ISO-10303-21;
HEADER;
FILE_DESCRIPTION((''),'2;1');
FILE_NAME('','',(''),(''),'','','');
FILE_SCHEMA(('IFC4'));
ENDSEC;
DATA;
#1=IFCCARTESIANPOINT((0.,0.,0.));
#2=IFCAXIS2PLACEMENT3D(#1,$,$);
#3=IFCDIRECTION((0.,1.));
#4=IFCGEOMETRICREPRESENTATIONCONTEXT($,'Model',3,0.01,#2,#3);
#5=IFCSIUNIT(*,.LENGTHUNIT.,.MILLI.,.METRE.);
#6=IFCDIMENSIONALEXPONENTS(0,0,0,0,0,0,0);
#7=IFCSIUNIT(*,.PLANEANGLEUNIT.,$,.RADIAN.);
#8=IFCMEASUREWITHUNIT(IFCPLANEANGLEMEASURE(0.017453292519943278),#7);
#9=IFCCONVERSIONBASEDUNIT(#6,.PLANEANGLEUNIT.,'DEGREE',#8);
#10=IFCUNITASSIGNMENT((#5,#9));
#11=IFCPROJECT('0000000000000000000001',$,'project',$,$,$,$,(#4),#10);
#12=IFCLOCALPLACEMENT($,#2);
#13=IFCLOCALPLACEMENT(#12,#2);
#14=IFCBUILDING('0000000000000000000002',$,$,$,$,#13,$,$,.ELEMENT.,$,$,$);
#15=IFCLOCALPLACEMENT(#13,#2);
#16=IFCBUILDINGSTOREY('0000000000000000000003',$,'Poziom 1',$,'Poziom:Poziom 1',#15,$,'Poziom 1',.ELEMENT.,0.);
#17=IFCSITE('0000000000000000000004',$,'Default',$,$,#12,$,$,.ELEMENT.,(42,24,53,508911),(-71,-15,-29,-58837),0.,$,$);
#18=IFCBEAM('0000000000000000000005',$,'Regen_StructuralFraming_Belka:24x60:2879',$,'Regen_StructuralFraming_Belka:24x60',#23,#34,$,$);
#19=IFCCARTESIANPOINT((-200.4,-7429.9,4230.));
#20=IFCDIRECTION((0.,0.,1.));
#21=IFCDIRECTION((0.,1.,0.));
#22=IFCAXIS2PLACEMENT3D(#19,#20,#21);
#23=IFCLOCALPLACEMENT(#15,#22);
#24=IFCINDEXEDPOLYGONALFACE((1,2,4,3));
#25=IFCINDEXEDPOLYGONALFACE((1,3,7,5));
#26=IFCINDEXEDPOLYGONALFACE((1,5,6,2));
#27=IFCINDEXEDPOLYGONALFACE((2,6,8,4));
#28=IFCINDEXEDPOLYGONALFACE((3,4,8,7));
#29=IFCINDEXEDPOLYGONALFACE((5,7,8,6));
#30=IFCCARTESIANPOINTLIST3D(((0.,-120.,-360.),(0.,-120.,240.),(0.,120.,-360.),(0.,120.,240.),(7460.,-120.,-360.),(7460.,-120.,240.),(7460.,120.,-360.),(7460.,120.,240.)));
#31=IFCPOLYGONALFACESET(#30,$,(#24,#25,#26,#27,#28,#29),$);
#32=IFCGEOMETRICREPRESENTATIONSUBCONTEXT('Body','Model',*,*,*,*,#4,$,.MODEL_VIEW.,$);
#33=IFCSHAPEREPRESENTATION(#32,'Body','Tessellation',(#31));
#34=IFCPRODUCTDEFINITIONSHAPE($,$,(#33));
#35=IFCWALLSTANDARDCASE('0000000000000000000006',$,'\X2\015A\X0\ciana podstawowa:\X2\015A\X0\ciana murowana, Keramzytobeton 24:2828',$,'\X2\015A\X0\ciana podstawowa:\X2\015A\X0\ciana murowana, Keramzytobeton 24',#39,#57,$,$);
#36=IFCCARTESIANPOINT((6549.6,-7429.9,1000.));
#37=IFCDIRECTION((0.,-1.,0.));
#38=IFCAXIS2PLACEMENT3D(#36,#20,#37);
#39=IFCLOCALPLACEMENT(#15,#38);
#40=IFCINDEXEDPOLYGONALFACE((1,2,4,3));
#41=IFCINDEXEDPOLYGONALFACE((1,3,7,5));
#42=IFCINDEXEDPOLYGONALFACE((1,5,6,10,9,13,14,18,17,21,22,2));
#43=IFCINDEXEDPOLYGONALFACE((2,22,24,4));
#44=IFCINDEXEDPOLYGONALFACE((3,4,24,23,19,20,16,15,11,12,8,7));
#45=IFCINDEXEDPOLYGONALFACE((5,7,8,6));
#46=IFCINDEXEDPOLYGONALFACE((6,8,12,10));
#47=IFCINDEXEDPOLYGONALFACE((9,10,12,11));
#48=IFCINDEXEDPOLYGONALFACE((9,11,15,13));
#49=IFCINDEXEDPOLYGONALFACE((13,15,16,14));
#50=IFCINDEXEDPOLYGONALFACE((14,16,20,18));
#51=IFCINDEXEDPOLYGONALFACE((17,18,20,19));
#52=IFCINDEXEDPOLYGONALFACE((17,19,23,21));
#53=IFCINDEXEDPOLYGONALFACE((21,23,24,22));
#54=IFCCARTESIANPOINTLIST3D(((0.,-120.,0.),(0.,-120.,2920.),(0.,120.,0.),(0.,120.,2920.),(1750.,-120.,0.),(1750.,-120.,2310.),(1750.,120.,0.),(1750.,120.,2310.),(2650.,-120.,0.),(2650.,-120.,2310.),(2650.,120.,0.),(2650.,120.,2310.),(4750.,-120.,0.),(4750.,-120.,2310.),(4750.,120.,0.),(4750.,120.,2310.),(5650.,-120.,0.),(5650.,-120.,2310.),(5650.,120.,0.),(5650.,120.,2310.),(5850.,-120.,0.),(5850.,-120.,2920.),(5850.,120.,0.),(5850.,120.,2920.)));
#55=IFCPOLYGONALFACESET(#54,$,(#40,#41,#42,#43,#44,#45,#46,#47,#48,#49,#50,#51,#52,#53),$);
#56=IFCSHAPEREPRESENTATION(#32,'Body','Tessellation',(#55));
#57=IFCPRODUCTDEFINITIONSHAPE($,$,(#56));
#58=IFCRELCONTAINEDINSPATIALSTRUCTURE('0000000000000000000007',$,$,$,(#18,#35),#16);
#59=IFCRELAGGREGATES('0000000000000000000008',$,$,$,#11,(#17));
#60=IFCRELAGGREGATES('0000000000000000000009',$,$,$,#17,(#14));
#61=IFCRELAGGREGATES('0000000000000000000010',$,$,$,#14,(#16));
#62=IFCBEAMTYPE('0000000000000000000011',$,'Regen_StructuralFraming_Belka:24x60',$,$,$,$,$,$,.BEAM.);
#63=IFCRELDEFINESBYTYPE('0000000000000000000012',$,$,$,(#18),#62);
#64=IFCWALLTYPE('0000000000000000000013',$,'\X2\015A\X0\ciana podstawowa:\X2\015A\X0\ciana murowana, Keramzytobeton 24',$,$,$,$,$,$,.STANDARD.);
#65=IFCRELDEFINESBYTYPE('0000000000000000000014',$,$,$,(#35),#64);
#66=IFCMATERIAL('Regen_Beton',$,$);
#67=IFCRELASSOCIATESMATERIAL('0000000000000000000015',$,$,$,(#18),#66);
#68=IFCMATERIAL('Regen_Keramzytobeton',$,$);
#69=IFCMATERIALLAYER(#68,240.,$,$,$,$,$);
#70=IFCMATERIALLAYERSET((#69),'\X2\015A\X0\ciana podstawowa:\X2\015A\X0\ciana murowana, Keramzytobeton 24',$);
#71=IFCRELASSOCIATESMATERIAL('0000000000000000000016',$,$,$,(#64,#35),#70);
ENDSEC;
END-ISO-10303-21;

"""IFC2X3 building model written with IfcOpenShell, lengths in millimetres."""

from ifc_helpers import new_model, entity, si_unit, converted_unit, direction, frame, frame_2d, origin, origin_2d_with_axis, place, context, subcontext, project, spatial, rectangle, extrude, material, layer, layer_set, layer_usage, type_object, element, save


model = new_model("IFC2X3")

# Units and contexts
model_context = context("Model", 3, precision=0.01, world=origin(), true_north=direction((0.0, 1.0)))
body_context = subcontext(model_context, "Body", "Model", "MODEL_VIEW")
ifc_project = project(units=[si_unit("LENGTHUNIT", "METRE", prefix="MILLI"), converted_unit("PLANEANGLEUNIT", "DEGREE", entity("IfcPlaneAngleMeasure", 0.017453292519943278), si_unit("PLANEANGLEUNIT", "RADIAN"), dimensions=[0, 0, 0, 0, 0, 0, 0])], contexts=[model_context])

# Site, building, storey
site_placement = place(None, origin())
site = spatial("IfcSite", under=ifc_project, at=site_placement, Name="Default", CompositionType="ELEMENT", RefLatitude=(42, 24, 53, 508911), RefLongitude=(-71, -15, -29, -58837), RefElevation=0.0)
building_placement = place(site_placement, origin())
building = spatial("IfcBuilding", under=site, at=building_placement, CompositionType="ELEMENT")
storey_placement = place(building_placement, origin())
storey = spatial("IfcBuildingStorey", under=building, at=storey_placement, Name="Poziom 1", ObjectType="Poziom:Poziom 1", LongName="Poziom 1", CompositionType="ELEMENT", Elevation=0.0)

# Beam
ifc_material_1 = material(Name="Regen_Beton")
beam_type_1 = type_object("IfcBeamType", Name="Regen_StructuralFraming_Belka:24x60", PredefinedType="BEAM")
beam_1_placement = place(storey_placement, frame((-200.4, -7429.9, 4230.0), z_axis=(0.0, 0.0, 1.0), x_axis=(0.0, 1.0, 0.0)))
element("IfcBeam", 1, at=beam_1_placement, inside=storey, type_object=beam_type_1, material=ifc_material_1, Name="Regen_StructuralFraming_Belka:24x60:2879", ObjectType="Regen_StructuralFraming_Belka:24x60", context=body_context, shape_type="SweptSolid", body=[
    extrude(rectangle(XDim=600.0, YDim=240.0, at=origin_2d_with_axis()), frame((0.0, 0.0, -60.0), z_axis=(1.0, 0.0, 0.0), x_axis=(0.0, 0.0, -1.0)), (0.0, 0.0, 1.0), 7460.0),
])

# Shared definitions
ifc_material_2 = material(Name="Regen_Keramzytobeton")
ifc_layer_1 = layer(ifc_material_2, 240.0)
ifc_layer_set_1 = layer_set([ifc_layer_1], Name="Ściana podstawowa:Ściana murowana, Keramzytobeton 24")
wall_type_1 = type_object("IfcWallType", Name="Ściana podstawowa:Ściana murowana, Keramzytobeton 24", PredefinedType="STANDARD", material=ifc_layer_set_1)

# Wall, openings
ifc_layer_usage_1 = layer_usage(ifc_layer_set_1, "AXIS2", "NEGATIVE", 120.0)
wall_1_placement = place(storey_placement, frame((6549.6, -7429.9, 1000.0), z_axis=(0.0, 0.0, 1.0), x_axis=(0.0, -1.0, 0.0)))
wall_1 = element("IfcWallStandardCase", 2, at=wall_1_placement, inside=storey, type_object=wall_type_1, material=ifc_layer_usage_1, Name="Ściana podstawowa:Ściana murowana, Keramzytobeton 24:2828", ObjectType="Ściana podstawowa:Ściana murowana, Keramzytobeton 24", context=body_context, shape_type="SweptSolid", body=[
    extrude(rectangle(XDim=240.0, YDim=5850.0, at=frame_2d((2925.0, 0.0), x_axis=(0.0, -1.0))), origin(), (0.0, 0.0, 1.0), 2920.0),
])
opening_1_placement = place(wall_1_placement, origin())
element("IfcOpeningElement", 3, at=opening_1_placement, cuts=wall_1, ObjectType="Opening", context=body_context, shape_type="SweptSolid", body=[
    extrude(rectangle(XDim=2310.0, YDim=900.0, at=frame_2d((0.0, 0.0), x_axis=(0.0, 1.0))), frame((2200.0, -1644.0, 1155.0), z_axis=(0.0, 1.0, 0.0), x_axis=(1.0, 0.0, 0.0)), (0.0, 0.0, 1.0), 3048.0),
])
opening_2_placement = place(wall_1_placement, origin())
element("IfcOpeningElement", 4, at=opening_2_placement, cuts=wall_1, ObjectType="Opening", context=body_context, shape_type="SweptSolid", body=[
    extrude(rectangle(XDim=2310.0, YDim=900.0, at=frame_2d((0.0, 0.0), x_axis=(0.0, 1.0))), frame((5200.0, -1644.0, 1155.0), z_axis=(0.0, 1.0, 0.0), x_axis=(1.0, 0.0, 0.0)), (0.0, 0.0, 1.0), 3048.0),
])

save(model, "model.ifc")
